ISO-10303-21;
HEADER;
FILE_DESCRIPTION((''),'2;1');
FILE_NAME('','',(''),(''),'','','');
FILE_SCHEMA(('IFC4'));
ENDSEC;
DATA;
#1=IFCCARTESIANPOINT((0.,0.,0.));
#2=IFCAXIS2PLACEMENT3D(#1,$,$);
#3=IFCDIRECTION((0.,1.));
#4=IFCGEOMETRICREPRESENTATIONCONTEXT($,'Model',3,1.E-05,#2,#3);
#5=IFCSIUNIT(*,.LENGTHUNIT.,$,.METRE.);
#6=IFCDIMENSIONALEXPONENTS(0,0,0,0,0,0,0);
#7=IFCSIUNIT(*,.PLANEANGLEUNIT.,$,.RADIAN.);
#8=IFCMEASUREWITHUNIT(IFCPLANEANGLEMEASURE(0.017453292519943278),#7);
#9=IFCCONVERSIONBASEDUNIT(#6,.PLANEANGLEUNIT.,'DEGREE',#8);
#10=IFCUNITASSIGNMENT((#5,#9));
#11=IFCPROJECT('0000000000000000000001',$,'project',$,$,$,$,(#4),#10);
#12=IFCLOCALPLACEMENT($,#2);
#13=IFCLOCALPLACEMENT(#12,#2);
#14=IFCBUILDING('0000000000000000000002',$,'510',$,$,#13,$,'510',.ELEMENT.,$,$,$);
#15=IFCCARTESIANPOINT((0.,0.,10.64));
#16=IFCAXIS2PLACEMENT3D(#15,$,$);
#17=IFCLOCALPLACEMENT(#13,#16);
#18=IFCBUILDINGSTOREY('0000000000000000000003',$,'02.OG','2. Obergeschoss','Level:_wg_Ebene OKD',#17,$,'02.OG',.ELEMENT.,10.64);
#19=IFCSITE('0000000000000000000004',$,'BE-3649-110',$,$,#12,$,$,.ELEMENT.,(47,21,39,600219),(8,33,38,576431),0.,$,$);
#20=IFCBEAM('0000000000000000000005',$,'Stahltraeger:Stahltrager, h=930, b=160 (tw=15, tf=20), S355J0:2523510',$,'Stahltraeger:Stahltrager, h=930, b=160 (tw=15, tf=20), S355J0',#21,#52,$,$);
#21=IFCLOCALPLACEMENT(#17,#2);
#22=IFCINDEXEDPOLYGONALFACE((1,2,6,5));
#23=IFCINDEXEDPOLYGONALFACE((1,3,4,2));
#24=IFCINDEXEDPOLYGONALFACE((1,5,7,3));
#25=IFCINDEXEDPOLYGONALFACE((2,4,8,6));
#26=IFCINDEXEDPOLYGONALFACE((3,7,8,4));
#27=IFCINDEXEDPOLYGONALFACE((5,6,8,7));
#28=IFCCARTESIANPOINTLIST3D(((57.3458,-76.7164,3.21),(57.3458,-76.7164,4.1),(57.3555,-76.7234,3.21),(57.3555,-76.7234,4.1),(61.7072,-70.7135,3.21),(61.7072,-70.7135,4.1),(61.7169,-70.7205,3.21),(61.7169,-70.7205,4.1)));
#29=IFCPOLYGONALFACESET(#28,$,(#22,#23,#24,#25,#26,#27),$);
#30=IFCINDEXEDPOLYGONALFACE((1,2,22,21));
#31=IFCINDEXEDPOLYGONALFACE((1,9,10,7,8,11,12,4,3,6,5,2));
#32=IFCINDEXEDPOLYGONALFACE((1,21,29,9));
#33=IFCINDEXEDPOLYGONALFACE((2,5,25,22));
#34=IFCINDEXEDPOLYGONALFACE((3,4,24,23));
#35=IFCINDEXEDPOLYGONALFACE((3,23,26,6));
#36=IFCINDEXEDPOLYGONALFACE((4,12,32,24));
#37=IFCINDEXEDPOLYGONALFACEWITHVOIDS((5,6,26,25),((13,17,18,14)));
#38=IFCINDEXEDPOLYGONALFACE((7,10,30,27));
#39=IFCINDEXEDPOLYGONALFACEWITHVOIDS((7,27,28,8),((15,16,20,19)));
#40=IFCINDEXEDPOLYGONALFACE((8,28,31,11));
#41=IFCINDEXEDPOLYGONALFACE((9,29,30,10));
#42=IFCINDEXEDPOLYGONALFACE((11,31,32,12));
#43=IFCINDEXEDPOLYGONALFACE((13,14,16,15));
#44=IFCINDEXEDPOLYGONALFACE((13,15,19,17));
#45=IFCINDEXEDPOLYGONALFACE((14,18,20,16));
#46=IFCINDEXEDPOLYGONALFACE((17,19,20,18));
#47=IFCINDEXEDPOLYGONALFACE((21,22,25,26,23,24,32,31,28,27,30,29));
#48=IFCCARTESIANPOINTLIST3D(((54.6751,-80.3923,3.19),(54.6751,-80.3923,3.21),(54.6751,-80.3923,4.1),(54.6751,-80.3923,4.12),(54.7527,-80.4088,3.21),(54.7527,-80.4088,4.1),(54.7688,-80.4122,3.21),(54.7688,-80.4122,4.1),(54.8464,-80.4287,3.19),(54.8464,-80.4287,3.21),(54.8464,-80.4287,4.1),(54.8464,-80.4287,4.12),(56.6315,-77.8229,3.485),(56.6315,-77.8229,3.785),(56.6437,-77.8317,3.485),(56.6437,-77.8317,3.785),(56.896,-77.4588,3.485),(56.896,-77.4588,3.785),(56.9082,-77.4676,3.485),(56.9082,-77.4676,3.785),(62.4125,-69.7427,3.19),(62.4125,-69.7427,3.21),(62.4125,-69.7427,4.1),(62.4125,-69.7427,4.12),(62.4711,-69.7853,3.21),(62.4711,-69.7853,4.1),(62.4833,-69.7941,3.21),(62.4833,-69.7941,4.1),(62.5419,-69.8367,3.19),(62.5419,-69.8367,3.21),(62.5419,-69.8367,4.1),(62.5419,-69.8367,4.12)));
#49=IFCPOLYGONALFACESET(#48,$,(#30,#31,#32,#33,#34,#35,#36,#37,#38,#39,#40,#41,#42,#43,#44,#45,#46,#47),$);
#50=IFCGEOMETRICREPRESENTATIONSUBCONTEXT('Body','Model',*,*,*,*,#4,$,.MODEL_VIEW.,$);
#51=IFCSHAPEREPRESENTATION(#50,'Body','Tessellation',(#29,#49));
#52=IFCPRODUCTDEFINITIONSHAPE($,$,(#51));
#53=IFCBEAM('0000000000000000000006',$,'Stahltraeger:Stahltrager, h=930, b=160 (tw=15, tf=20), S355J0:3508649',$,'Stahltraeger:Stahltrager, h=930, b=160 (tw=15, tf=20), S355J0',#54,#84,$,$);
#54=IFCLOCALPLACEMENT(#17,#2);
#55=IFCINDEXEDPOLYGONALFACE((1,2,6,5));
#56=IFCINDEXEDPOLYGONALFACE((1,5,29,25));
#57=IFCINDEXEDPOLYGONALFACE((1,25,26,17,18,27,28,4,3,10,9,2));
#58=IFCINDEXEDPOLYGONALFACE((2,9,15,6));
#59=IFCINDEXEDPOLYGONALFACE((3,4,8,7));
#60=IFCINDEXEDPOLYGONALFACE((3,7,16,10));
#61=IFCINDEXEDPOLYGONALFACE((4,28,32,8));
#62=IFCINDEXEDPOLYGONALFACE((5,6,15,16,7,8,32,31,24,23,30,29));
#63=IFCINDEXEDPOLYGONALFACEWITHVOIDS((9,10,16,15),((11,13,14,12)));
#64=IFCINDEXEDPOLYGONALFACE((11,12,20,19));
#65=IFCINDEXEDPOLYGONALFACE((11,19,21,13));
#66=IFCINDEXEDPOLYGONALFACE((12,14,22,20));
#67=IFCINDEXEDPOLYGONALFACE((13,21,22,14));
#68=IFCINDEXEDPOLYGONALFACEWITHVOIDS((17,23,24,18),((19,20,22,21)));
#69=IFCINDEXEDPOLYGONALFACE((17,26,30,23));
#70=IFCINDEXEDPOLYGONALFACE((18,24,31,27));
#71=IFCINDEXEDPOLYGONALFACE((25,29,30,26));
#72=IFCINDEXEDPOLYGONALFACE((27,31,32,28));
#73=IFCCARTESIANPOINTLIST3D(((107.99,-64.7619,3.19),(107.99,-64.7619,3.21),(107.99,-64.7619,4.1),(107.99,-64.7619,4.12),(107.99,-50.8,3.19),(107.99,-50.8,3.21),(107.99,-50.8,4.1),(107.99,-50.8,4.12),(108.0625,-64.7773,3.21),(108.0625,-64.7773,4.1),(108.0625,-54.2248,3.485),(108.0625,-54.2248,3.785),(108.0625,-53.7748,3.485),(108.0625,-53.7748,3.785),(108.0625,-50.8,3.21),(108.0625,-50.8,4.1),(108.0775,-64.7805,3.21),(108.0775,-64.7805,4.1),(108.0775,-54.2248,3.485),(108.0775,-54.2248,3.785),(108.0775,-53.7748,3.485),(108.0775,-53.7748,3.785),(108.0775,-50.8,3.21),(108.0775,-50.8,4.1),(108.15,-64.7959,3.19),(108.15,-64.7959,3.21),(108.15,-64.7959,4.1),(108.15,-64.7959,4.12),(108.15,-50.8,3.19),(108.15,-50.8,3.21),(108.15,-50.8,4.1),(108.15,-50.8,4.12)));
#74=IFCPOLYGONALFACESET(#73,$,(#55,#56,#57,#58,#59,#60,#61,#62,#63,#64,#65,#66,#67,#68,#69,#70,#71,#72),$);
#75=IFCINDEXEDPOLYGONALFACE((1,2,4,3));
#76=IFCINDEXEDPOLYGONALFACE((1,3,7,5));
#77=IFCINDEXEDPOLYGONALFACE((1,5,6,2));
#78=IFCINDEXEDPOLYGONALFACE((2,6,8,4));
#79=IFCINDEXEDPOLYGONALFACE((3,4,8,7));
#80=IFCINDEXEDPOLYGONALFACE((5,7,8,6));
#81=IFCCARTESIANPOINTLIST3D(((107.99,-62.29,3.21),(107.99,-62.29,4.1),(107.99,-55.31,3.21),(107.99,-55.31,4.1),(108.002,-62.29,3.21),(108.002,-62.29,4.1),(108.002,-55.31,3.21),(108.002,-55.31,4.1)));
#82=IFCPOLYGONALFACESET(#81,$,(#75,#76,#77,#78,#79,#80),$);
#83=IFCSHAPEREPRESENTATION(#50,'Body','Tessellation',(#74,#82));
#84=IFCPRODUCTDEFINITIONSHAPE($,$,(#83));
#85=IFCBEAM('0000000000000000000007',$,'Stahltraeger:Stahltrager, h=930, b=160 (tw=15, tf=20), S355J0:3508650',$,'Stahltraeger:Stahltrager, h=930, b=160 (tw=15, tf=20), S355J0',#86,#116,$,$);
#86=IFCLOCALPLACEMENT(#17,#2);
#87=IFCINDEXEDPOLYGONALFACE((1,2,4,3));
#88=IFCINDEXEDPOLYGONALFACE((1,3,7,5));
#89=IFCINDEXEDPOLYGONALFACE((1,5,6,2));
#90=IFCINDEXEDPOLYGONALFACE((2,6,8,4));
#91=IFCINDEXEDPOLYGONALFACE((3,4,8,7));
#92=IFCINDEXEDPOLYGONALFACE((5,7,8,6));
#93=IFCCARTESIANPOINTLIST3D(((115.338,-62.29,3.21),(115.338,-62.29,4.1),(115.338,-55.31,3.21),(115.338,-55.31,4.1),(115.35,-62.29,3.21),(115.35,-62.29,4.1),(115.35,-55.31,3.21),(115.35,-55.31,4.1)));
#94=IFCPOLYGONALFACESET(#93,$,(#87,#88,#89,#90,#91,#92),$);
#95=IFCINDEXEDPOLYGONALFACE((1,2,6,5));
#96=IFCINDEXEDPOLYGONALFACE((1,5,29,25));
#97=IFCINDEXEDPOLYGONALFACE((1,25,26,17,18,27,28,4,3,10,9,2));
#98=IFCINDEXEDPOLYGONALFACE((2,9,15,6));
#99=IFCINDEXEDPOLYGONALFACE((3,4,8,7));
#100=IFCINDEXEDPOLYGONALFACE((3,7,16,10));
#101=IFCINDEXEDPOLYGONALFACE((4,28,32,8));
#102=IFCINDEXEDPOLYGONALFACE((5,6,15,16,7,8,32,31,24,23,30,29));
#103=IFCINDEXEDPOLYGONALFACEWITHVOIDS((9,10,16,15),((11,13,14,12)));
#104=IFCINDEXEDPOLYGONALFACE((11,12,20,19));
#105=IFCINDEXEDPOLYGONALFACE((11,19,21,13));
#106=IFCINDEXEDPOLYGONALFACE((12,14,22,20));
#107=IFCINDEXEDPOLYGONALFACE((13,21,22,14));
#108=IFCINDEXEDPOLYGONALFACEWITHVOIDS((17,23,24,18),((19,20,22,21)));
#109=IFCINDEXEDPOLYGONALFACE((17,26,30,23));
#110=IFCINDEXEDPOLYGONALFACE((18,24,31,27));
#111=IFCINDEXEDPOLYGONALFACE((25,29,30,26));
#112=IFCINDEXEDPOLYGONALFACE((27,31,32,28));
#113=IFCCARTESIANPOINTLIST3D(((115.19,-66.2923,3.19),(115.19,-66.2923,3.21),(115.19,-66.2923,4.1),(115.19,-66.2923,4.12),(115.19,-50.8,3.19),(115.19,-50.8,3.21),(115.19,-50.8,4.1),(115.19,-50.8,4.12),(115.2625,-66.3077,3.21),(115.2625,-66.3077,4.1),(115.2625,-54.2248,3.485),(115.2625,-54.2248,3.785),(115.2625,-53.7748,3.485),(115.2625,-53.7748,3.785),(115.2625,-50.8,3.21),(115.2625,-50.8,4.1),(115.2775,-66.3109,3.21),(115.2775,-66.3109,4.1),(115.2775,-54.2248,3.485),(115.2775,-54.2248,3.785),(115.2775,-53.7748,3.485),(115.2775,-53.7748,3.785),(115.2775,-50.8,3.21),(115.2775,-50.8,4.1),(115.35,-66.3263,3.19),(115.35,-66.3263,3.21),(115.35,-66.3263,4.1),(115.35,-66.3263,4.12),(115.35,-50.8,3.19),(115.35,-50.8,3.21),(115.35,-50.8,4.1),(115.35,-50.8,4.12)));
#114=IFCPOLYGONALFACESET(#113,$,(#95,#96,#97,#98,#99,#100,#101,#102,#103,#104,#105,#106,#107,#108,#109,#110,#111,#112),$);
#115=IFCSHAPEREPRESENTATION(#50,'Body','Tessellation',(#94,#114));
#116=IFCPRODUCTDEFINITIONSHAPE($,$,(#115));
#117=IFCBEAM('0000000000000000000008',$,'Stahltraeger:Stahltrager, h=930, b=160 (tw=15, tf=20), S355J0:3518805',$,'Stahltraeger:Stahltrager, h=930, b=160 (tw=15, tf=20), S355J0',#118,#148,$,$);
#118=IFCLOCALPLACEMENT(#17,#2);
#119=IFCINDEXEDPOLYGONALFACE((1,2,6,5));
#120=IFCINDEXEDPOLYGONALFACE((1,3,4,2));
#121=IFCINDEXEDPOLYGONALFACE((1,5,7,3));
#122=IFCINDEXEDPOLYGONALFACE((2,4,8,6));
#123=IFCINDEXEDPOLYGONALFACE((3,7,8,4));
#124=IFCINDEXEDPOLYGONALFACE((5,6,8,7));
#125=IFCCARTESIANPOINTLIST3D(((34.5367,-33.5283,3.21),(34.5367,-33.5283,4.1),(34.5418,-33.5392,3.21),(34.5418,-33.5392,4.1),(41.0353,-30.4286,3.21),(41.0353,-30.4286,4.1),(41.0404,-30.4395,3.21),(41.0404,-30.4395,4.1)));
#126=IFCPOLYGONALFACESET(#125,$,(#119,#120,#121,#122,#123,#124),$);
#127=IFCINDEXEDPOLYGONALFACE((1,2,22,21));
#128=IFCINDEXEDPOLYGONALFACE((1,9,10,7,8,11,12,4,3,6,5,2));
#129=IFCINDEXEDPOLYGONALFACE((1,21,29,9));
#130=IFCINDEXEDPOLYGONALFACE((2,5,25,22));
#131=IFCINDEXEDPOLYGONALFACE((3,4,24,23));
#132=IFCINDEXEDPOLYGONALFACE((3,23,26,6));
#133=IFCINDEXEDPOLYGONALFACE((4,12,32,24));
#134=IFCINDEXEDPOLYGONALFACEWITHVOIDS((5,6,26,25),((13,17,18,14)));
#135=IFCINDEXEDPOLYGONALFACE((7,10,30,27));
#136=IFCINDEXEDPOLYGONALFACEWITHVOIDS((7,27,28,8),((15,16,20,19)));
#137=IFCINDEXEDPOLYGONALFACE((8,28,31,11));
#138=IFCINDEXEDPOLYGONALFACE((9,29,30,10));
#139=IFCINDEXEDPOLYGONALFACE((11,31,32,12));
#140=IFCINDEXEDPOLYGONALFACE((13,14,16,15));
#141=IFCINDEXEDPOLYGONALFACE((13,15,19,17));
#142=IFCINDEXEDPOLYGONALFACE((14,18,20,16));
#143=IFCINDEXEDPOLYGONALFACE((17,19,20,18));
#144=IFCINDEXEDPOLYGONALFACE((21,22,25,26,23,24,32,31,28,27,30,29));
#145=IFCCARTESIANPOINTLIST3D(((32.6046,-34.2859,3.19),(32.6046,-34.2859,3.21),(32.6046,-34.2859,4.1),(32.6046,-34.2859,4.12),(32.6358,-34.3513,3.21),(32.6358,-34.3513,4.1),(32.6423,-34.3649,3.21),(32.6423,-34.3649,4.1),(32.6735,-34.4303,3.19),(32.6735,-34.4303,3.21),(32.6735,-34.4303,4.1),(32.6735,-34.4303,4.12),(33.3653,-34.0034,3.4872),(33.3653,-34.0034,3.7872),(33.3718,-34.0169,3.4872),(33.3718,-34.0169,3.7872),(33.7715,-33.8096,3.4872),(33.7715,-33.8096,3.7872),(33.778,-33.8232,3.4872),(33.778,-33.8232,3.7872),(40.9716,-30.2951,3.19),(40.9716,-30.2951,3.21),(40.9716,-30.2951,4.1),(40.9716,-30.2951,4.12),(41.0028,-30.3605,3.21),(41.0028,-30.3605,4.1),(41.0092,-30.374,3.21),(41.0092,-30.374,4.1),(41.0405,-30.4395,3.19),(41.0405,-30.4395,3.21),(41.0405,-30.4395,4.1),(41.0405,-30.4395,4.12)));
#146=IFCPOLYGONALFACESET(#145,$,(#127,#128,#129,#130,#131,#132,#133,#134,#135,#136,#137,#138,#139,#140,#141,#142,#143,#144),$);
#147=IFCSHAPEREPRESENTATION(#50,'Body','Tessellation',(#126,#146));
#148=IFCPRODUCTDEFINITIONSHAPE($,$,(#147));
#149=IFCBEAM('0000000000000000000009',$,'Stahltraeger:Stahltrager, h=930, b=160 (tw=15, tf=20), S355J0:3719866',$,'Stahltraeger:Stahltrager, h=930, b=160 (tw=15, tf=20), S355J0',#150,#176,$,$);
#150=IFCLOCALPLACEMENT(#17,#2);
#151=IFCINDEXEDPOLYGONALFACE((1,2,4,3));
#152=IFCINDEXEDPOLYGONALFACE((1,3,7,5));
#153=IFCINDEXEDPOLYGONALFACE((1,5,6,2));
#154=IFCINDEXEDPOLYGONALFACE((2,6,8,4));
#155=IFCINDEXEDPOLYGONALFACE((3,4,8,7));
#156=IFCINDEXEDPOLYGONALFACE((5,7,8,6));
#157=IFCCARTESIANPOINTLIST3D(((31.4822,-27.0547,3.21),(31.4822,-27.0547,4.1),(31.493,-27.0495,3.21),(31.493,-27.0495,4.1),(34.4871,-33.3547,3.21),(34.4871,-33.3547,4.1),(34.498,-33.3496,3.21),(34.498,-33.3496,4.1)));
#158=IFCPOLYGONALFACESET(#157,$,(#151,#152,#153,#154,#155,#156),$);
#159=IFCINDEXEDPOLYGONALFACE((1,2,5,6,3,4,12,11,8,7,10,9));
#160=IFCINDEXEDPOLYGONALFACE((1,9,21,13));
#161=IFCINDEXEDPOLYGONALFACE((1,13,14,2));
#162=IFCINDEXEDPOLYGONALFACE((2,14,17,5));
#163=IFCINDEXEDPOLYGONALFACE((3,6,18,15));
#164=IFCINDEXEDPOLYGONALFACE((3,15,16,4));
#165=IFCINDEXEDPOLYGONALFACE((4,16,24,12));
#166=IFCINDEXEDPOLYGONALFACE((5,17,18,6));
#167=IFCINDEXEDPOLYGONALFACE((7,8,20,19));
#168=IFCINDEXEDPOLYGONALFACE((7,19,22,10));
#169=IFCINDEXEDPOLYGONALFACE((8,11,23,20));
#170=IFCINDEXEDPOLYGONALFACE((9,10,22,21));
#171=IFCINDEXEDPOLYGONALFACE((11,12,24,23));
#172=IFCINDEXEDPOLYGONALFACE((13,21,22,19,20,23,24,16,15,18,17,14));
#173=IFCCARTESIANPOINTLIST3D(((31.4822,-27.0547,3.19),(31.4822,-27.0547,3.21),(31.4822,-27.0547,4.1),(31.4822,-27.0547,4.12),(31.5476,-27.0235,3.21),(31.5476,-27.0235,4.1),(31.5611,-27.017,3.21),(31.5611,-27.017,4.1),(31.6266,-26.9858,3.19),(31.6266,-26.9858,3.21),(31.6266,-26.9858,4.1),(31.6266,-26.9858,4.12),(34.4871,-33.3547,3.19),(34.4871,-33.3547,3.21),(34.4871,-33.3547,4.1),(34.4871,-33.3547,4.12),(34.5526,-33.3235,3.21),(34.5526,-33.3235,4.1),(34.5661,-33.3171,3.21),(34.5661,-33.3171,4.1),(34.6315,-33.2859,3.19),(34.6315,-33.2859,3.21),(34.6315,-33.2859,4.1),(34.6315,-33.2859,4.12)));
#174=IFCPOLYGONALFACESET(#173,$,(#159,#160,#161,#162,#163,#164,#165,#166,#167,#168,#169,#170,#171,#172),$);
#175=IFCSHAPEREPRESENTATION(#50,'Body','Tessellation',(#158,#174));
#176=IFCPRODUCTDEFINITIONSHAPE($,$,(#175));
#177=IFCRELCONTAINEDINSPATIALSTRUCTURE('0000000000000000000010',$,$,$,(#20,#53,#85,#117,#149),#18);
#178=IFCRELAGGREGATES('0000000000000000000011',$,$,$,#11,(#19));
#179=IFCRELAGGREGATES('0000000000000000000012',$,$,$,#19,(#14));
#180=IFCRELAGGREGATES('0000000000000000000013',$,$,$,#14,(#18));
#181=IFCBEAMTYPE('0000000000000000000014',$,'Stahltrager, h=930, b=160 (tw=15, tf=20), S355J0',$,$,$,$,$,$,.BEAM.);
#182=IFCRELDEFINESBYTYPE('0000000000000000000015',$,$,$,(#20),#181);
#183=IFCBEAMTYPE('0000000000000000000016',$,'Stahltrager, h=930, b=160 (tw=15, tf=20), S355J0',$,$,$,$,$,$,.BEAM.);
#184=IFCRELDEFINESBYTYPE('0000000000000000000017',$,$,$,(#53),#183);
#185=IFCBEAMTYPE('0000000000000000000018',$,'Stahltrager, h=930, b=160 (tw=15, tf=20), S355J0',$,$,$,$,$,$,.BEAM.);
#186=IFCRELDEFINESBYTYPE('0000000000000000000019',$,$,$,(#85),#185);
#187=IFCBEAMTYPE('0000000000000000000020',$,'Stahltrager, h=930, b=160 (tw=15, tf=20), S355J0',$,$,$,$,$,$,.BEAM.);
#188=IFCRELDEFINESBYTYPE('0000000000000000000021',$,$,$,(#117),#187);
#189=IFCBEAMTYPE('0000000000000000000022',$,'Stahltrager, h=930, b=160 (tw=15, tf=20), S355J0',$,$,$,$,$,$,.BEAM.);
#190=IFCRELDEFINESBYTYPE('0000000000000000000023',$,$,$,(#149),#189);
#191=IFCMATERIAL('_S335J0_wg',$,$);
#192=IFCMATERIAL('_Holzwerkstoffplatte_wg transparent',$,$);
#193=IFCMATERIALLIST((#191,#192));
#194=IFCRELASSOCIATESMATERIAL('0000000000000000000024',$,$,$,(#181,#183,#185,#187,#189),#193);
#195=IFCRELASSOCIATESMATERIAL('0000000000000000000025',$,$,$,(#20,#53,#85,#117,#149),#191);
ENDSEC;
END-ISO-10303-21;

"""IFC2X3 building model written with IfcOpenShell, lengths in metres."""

from ifc_helpers import new_model, entity, si_unit, converted_unit, direction, frame, frame_2d, origin, place, context, subcontext, project, spatial, rectangle, i_section, extrude, boolean, clip, halfspace, source, transform, mapped, material, material_list, type_object, type_shapes, element, save


model = new_model("IFC2X3")

# Units and contexts
model_context = context("Model", 3, precision=1e-05, world=origin(), true_north=direction((0.0, 1.0)))
body_context = subcontext(model_context, "Body", "Model", "MODEL_VIEW")
ifc_project = project(units=[si_unit("LENGTHUNIT", "METRE"), converted_unit("PLANEANGLEUNIT", "DEGREE", entity("IfcPlaneAngleMeasure", 0.017453292519943278), si_unit("PLANEANGLEUNIT", "RADIAN"), dimensions=[0, 0, 0, 0, 0, 0, 0])], contexts=[model_context])

# Site, building, storey
site_placement = place(None, origin())
site = spatial("IfcSite", under=ifc_project, at=site_placement, Name="BE-3649-110", CompositionType="ELEMENT", RefLatitude=(47, 21, 39, 600219), RefLongitude=(8, 33, 38, 576431), RefElevation=0.0)
building_placement = place(site_placement, origin())
building = spatial("IfcBuilding", under=site, at=building_placement, Name="510", LongName="510", CompositionType="ELEMENT")
storey_placement = place(building_placement, frame((0.0, 0.0, 10.64)))
storey = spatial("IfcBuildingStorey", under=building, at=storey_placement, Name="02.OG", Description="2. Obergeschoss", ObjectType="Level:_wg_Ebene OKD", LongName="02.OG", CompositionType="ELEMENT", Elevation=10.64)

# Beams
ifc_material_1 = material(Name="_S335J0_wg")
ifc_material_2 = material(Name="_Holzwerkstoffplatte_wg transparent")
ifc_material_list = material_list([ifc_material_1, ifc_material_2])
beam_type_1 = type_object("IfcBeamType", Name="Stahltrager, h=930, b=160 (tw=15, tf=20), S355J0", PredefinedType="BEAM", material=ifc_material_list)
shared_shape_1 = source(origin(), body_context, "Body", "SweptSolid", [
    extrude(rectangle(XDim=0.89, YDim=0.012, at=frame_2d((0.0, 0.0), x_axis=(1.0, 0.0))), frame((61.712, -70.717, 14.295), z_axis=(-0.587785, -0.809017, 0.0), x_axis=(0.0, 0.0, -1.0)), (0.0, 0.0, 1.0), 7.42),
    boolean("DIFFERENCE", clip(extrude(i_section(OverallWidth=0.16, OverallDepth=0.93, WebThickness=0.015, FlangeThickness=0.02, at=frame_2d((0.0, 0.0), x_axis=(0.0, 1.0))), frame((62.4772, -69.7897, 14.295), z_axis=(-0.587785, -0.809017, 0.0), x_axis=(0.0, 0.0, -1.0)), (0.0, 0.0, 1.0), 13.1636), halfspace(frame((55.5492, -80.5781, 27.5453), z_axis=(-0.207912, -0.978148, 0.0), x_axis=(0.0, 0.0, -1.0)), False)), extrude(rectangle(XDim=0.3, YDim=0.45, at=frame_2d((0.0, 0.0), x_axis=(0.0, 1.0))), frame((56.7759, -77.6497, 14.275), z_axis=(-0.809017, 0.587785, 0.0), x_axis=(0.587785, 0.809017, 0.0)), (0.0, 0.0, 1.0), 0.015)),
])
type_shapes(beam_type_1, [shared_shape_1])
beam_1_placement = place(storey_placement, frame((0.0, 0.0, -10.64)))
element("IfcBeam", 1, at=beam_1_placement, inside=storey, type_object=beam_type_1, material=ifc_material_1, Name="Stahltraeger:Stahltrager, h=930, b=160 (tw=15, tf=20), S355J0:2523510", ObjectType="Stahltraeger:Stahltrager, h=930, b=160 (tw=15, tf=20), S355J0", context=body_context, shape_type="MappedRepresentation", body=[
    mapped(shared_shape_1, transform((0.0, 0.0, 0.0), scale=1.0)),
])
beam_type_2 = type_object("IfcBeamType", Name="Stahltrager, h=930, b=160 (tw=15, tf=20), S355J0", PredefinedType="BEAM", material=ifc_material_list)
shared_shape_2 = source(origin(), body_context, "Body", "SweptSolid", [
    boolean("DIFFERENCE", clip(extrude(i_section(OverallWidth=0.16, OverallDepth=0.93, WebThickness=0.015, FlangeThickness=0.02, at=frame_2d((0.0, 0.0), x_axis=(1.0, 0.0))), frame((108.07, -50.8, 14.295), z_axis=(0.0, -1.0, 0.0), x_axis=(-1.0, 0.0, 0.0)), (0.0, 0.0, 1.0), 13.9959), halfspace(frame((108.39, -64.8469, -0.22), z_axis=(-0.207912, -0.978148, 0.0), x_axis=(-0.978148, 0.207912, 0.0)), False)), extrude(rectangle(XDim=0.3, YDim=0.45, at=frame_2d((0.0, 0.0), x_axis=(0.0, 1.0))), frame((108.0625, -53.9998, 14.275), z_axis=(1.0, 0.0, 0.0), x_axis=(0.0, -1.0, 0.0)), (0.0, 0.0, 1.0), 0.015)),
    extrude(rectangle(XDim=0.89, YDim=0.012, at=frame_2d((0.0, 0.0), x_axis=(0.0, 1.0))), frame((107.996, -55.31, 14.295), z_axis=(0.0, -1.0, 0.0), x_axis=(-1.0, 0.0, 0.0)), (0.0, 0.0, 1.0), 6.98),
])
type_shapes(beam_type_2, [shared_shape_2])
beam_2_placement = place(storey_placement, frame((0.0, 0.0, -10.64)))
element("IfcBeam", 2, at=beam_2_placement, inside=storey, type_object=beam_type_2, material=ifc_material_1, Name="Stahltraeger:Stahltrager, h=930, b=160 (tw=15, tf=20), S355J0:3508649", ObjectType="Stahltraeger:Stahltrager, h=930, b=160 (tw=15, tf=20), S355J0", context=body_context, shape_type="MappedRepresentation", body=[
    mapped(shared_shape_2, transform((0.0, 0.0, 0.0), scale=1.0)),
])
beam_type_3 = type_object("IfcBeamType", Name="Stahltrager, h=930, b=160 (tw=15, tf=20), S355J0", PredefinedType="BEAM", material=ifc_material_list)
shared_shape_3 = source(origin(), body_context, "Body", "SweptSolid", [
    extrude(rectangle(XDim=0.89, YDim=0.012, at=frame_2d((0.0, 0.0), x_axis=(0.0, 1.0))), frame((115.344, -55.31, 14.295), z_axis=(0.0, -1.0, 0.0), x_axis=(-1.0, 0.0, 0.0)), (0.0, 0.0, 1.0), 6.98),
    boolean("DIFFERENCE", clip(extrude(i_section(OverallWidth=0.16, OverallDepth=0.93, WebThickness=0.015, FlangeThickness=0.02, at=frame_2d((0.0, 0.0), x_axis=(1.0, 0.0))), frame((115.27, -50.8, 14.295), z_axis=(0.0, -1.0, 0.0), x_axis=(-1.0, 0.0, 0.0)), (0.0, 0.0, 1.0), 15.5263), halfspace(frame((115.7261, -66.4062, -0.22), z_axis=(-0.207912, -0.978148, 0.0), x_axis=(-0.978148, 0.207912, 0.0)), False)), extrude(rectangle(XDim=0.3, YDim=0.45, at=frame_2d((0.0, 0.0), x_axis=(0.0, 1.0))), frame((115.2625, -53.9998, 14.275), z_axis=(1.0, 0.0, 0.0), x_axis=(0.0, -1.0, 0.0)), (0.0, 0.0, 1.0), 0.015)),
])
type_shapes(beam_type_3, [shared_shape_3])
beam_3_placement = place(storey_placement, frame((0.0, 0.0, -10.64)))
element("IfcBeam", 3, at=beam_3_placement, inside=storey, type_object=beam_type_3, material=ifc_material_1, Name="Stahltraeger:Stahltrager, h=930, b=160 (tw=15, tf=20), S355J0:3508650", ObjectType="Stahltraeger:Stahltrager, h=930, b=160 (tw=15, tf=20), S355J0", context=body_context, shape_type="MappedRepresentation", body=[
    mapped(shared_shape_3, transform((0.0, 0.0, 0.0), scale=1.0)),
])
beam_type_4 = type_object("IfcBeamType", Name="Stahltrager, h=930, b=160 (tw=15, tf=20), S355J0", PredefinedType="BEAM", material=ifc_material_list)
shared_shape_4 = source(origin(), body_context, "Body", "SweptSolid", [
    extrude(rectangle(XDim=0.89, YDim=0.012, at=frame_2d((0.0, 0.0), x_axis=(1.0, 0.0))), frame((41.0379, -30.4341, 14.295), z_axis=(-0.902585, -0.430511, 0.0), x_axis=(0.0, 0.0, -1.0)), (0.0, 0.0, 1.0), 7.2),
    boolean("DIFFERENCE", extrude(i_section(OverallWidth=0.16, OverallDepth=0.93, WebThickness=0.015, FlangeThickness=0.02, at=frame_2d((0.0, 0.0), x_axis=(0.0, 1.0))), frame((41.006, -30.3673, 14.295), z_axis=(-0.902585, -0.430511, 0.0), x_axis=(0.0, 0.0, -1.0)), (0.0, 0.0, 1.0), 9.27), extrude(rectangle(XDim=0.3, YDim=0.45, at=frame_2d((0.0, 0.0), x_axis=(0.0, 1.0))), frame((33.5749, -33.92, 14.2772), z_axis=(-0.430511, 0.902585, 0.0), x_axis=(0.902585, 0.430511, 0.0)), (0.0, 0.0, 1.0), 0.015)),
])
type_shapes(beam_type_4, [shared_shape_4])
beam_4_placement = place(storey_placement, frame((0.0, 0.0, -10.64)))
element("IfcBeam", 4, at=beam_4_placement, inside=storey, type_object=beam_type_4, material=ifc_material_1, Name="Stahltraeger:Stahltrager, h=930, b=160 (tw=15, tf=20), S355J0:3518805", ObjectType="Stahltraeger:Stahltrager, h=930, b=160 (tw=15, tf=20), S355J0", context=body_context, shape_type="MappedRepresentation", body=[
    mapped(shared_shape_4, transform((0.0, 0.0, 0.0), scale=1.0)),
])
beam_type_5 = type_object("IfcBeamType", Name="Stahltrager, h=930, b=160 (tw=15, tf=20), S355J0", PredefinedType="BEAM", material=ifc_material_list)
shared_shape_5 = source(origin(), body_context, "Body", "SweptSolid", [
    extrude(rectangle(XDim=0.89, YDim=0.012, at=frame_2d((0.0, 0.0), x_axis=(1.0, 0.0))), frame((31.4876, -27.0521, 14.295), z_axis=(0.430511, -0.902585, 0.0), x_axis=(0.0, 0.0, -1.0)), (0.0, 0.0, 1.0), 6.98),
    extrude(i_section(OverallWidth=0.16, OverallDepth=0.93, WebThickness=0.015, FlangeThickness=0.02, at=frame_2d((0.0, 0.0), x_axis=(0.0, 1.0))), frame((31.5544, -27.0203, 14.295), z_axis=(0.430511, -0.902585, 0.0), x_axis=(0.0, 0.0, -1.0)), (0.0, 0.0, 1.0), 6.98),
])
type_shapes(beam_type_5, [shared_shape_5])
beam_5_placement = place(storey_placement, frame((0.0, 0.0, -10.64)))
element("IfcBeam", 5, at=beam_5_placement, inside=storey, type_object=beam_type_5, material=ifc_material_1, Name="Stahltraeger:Stahltrager, h=930, b=160 (tw=15, tf=20), S355J0:3719866", ObjectType="Stahltraeger:Stahltrager, h=930, b=160 (tw=15, tf=20), S355J0", context=body_context, shape_type="MappedRepresentation", body=[
    mapped(shared_shape_5, transform((0.0, 0.0, 0.0), scale=1.0)),
])

save(model, "model.ifc")
